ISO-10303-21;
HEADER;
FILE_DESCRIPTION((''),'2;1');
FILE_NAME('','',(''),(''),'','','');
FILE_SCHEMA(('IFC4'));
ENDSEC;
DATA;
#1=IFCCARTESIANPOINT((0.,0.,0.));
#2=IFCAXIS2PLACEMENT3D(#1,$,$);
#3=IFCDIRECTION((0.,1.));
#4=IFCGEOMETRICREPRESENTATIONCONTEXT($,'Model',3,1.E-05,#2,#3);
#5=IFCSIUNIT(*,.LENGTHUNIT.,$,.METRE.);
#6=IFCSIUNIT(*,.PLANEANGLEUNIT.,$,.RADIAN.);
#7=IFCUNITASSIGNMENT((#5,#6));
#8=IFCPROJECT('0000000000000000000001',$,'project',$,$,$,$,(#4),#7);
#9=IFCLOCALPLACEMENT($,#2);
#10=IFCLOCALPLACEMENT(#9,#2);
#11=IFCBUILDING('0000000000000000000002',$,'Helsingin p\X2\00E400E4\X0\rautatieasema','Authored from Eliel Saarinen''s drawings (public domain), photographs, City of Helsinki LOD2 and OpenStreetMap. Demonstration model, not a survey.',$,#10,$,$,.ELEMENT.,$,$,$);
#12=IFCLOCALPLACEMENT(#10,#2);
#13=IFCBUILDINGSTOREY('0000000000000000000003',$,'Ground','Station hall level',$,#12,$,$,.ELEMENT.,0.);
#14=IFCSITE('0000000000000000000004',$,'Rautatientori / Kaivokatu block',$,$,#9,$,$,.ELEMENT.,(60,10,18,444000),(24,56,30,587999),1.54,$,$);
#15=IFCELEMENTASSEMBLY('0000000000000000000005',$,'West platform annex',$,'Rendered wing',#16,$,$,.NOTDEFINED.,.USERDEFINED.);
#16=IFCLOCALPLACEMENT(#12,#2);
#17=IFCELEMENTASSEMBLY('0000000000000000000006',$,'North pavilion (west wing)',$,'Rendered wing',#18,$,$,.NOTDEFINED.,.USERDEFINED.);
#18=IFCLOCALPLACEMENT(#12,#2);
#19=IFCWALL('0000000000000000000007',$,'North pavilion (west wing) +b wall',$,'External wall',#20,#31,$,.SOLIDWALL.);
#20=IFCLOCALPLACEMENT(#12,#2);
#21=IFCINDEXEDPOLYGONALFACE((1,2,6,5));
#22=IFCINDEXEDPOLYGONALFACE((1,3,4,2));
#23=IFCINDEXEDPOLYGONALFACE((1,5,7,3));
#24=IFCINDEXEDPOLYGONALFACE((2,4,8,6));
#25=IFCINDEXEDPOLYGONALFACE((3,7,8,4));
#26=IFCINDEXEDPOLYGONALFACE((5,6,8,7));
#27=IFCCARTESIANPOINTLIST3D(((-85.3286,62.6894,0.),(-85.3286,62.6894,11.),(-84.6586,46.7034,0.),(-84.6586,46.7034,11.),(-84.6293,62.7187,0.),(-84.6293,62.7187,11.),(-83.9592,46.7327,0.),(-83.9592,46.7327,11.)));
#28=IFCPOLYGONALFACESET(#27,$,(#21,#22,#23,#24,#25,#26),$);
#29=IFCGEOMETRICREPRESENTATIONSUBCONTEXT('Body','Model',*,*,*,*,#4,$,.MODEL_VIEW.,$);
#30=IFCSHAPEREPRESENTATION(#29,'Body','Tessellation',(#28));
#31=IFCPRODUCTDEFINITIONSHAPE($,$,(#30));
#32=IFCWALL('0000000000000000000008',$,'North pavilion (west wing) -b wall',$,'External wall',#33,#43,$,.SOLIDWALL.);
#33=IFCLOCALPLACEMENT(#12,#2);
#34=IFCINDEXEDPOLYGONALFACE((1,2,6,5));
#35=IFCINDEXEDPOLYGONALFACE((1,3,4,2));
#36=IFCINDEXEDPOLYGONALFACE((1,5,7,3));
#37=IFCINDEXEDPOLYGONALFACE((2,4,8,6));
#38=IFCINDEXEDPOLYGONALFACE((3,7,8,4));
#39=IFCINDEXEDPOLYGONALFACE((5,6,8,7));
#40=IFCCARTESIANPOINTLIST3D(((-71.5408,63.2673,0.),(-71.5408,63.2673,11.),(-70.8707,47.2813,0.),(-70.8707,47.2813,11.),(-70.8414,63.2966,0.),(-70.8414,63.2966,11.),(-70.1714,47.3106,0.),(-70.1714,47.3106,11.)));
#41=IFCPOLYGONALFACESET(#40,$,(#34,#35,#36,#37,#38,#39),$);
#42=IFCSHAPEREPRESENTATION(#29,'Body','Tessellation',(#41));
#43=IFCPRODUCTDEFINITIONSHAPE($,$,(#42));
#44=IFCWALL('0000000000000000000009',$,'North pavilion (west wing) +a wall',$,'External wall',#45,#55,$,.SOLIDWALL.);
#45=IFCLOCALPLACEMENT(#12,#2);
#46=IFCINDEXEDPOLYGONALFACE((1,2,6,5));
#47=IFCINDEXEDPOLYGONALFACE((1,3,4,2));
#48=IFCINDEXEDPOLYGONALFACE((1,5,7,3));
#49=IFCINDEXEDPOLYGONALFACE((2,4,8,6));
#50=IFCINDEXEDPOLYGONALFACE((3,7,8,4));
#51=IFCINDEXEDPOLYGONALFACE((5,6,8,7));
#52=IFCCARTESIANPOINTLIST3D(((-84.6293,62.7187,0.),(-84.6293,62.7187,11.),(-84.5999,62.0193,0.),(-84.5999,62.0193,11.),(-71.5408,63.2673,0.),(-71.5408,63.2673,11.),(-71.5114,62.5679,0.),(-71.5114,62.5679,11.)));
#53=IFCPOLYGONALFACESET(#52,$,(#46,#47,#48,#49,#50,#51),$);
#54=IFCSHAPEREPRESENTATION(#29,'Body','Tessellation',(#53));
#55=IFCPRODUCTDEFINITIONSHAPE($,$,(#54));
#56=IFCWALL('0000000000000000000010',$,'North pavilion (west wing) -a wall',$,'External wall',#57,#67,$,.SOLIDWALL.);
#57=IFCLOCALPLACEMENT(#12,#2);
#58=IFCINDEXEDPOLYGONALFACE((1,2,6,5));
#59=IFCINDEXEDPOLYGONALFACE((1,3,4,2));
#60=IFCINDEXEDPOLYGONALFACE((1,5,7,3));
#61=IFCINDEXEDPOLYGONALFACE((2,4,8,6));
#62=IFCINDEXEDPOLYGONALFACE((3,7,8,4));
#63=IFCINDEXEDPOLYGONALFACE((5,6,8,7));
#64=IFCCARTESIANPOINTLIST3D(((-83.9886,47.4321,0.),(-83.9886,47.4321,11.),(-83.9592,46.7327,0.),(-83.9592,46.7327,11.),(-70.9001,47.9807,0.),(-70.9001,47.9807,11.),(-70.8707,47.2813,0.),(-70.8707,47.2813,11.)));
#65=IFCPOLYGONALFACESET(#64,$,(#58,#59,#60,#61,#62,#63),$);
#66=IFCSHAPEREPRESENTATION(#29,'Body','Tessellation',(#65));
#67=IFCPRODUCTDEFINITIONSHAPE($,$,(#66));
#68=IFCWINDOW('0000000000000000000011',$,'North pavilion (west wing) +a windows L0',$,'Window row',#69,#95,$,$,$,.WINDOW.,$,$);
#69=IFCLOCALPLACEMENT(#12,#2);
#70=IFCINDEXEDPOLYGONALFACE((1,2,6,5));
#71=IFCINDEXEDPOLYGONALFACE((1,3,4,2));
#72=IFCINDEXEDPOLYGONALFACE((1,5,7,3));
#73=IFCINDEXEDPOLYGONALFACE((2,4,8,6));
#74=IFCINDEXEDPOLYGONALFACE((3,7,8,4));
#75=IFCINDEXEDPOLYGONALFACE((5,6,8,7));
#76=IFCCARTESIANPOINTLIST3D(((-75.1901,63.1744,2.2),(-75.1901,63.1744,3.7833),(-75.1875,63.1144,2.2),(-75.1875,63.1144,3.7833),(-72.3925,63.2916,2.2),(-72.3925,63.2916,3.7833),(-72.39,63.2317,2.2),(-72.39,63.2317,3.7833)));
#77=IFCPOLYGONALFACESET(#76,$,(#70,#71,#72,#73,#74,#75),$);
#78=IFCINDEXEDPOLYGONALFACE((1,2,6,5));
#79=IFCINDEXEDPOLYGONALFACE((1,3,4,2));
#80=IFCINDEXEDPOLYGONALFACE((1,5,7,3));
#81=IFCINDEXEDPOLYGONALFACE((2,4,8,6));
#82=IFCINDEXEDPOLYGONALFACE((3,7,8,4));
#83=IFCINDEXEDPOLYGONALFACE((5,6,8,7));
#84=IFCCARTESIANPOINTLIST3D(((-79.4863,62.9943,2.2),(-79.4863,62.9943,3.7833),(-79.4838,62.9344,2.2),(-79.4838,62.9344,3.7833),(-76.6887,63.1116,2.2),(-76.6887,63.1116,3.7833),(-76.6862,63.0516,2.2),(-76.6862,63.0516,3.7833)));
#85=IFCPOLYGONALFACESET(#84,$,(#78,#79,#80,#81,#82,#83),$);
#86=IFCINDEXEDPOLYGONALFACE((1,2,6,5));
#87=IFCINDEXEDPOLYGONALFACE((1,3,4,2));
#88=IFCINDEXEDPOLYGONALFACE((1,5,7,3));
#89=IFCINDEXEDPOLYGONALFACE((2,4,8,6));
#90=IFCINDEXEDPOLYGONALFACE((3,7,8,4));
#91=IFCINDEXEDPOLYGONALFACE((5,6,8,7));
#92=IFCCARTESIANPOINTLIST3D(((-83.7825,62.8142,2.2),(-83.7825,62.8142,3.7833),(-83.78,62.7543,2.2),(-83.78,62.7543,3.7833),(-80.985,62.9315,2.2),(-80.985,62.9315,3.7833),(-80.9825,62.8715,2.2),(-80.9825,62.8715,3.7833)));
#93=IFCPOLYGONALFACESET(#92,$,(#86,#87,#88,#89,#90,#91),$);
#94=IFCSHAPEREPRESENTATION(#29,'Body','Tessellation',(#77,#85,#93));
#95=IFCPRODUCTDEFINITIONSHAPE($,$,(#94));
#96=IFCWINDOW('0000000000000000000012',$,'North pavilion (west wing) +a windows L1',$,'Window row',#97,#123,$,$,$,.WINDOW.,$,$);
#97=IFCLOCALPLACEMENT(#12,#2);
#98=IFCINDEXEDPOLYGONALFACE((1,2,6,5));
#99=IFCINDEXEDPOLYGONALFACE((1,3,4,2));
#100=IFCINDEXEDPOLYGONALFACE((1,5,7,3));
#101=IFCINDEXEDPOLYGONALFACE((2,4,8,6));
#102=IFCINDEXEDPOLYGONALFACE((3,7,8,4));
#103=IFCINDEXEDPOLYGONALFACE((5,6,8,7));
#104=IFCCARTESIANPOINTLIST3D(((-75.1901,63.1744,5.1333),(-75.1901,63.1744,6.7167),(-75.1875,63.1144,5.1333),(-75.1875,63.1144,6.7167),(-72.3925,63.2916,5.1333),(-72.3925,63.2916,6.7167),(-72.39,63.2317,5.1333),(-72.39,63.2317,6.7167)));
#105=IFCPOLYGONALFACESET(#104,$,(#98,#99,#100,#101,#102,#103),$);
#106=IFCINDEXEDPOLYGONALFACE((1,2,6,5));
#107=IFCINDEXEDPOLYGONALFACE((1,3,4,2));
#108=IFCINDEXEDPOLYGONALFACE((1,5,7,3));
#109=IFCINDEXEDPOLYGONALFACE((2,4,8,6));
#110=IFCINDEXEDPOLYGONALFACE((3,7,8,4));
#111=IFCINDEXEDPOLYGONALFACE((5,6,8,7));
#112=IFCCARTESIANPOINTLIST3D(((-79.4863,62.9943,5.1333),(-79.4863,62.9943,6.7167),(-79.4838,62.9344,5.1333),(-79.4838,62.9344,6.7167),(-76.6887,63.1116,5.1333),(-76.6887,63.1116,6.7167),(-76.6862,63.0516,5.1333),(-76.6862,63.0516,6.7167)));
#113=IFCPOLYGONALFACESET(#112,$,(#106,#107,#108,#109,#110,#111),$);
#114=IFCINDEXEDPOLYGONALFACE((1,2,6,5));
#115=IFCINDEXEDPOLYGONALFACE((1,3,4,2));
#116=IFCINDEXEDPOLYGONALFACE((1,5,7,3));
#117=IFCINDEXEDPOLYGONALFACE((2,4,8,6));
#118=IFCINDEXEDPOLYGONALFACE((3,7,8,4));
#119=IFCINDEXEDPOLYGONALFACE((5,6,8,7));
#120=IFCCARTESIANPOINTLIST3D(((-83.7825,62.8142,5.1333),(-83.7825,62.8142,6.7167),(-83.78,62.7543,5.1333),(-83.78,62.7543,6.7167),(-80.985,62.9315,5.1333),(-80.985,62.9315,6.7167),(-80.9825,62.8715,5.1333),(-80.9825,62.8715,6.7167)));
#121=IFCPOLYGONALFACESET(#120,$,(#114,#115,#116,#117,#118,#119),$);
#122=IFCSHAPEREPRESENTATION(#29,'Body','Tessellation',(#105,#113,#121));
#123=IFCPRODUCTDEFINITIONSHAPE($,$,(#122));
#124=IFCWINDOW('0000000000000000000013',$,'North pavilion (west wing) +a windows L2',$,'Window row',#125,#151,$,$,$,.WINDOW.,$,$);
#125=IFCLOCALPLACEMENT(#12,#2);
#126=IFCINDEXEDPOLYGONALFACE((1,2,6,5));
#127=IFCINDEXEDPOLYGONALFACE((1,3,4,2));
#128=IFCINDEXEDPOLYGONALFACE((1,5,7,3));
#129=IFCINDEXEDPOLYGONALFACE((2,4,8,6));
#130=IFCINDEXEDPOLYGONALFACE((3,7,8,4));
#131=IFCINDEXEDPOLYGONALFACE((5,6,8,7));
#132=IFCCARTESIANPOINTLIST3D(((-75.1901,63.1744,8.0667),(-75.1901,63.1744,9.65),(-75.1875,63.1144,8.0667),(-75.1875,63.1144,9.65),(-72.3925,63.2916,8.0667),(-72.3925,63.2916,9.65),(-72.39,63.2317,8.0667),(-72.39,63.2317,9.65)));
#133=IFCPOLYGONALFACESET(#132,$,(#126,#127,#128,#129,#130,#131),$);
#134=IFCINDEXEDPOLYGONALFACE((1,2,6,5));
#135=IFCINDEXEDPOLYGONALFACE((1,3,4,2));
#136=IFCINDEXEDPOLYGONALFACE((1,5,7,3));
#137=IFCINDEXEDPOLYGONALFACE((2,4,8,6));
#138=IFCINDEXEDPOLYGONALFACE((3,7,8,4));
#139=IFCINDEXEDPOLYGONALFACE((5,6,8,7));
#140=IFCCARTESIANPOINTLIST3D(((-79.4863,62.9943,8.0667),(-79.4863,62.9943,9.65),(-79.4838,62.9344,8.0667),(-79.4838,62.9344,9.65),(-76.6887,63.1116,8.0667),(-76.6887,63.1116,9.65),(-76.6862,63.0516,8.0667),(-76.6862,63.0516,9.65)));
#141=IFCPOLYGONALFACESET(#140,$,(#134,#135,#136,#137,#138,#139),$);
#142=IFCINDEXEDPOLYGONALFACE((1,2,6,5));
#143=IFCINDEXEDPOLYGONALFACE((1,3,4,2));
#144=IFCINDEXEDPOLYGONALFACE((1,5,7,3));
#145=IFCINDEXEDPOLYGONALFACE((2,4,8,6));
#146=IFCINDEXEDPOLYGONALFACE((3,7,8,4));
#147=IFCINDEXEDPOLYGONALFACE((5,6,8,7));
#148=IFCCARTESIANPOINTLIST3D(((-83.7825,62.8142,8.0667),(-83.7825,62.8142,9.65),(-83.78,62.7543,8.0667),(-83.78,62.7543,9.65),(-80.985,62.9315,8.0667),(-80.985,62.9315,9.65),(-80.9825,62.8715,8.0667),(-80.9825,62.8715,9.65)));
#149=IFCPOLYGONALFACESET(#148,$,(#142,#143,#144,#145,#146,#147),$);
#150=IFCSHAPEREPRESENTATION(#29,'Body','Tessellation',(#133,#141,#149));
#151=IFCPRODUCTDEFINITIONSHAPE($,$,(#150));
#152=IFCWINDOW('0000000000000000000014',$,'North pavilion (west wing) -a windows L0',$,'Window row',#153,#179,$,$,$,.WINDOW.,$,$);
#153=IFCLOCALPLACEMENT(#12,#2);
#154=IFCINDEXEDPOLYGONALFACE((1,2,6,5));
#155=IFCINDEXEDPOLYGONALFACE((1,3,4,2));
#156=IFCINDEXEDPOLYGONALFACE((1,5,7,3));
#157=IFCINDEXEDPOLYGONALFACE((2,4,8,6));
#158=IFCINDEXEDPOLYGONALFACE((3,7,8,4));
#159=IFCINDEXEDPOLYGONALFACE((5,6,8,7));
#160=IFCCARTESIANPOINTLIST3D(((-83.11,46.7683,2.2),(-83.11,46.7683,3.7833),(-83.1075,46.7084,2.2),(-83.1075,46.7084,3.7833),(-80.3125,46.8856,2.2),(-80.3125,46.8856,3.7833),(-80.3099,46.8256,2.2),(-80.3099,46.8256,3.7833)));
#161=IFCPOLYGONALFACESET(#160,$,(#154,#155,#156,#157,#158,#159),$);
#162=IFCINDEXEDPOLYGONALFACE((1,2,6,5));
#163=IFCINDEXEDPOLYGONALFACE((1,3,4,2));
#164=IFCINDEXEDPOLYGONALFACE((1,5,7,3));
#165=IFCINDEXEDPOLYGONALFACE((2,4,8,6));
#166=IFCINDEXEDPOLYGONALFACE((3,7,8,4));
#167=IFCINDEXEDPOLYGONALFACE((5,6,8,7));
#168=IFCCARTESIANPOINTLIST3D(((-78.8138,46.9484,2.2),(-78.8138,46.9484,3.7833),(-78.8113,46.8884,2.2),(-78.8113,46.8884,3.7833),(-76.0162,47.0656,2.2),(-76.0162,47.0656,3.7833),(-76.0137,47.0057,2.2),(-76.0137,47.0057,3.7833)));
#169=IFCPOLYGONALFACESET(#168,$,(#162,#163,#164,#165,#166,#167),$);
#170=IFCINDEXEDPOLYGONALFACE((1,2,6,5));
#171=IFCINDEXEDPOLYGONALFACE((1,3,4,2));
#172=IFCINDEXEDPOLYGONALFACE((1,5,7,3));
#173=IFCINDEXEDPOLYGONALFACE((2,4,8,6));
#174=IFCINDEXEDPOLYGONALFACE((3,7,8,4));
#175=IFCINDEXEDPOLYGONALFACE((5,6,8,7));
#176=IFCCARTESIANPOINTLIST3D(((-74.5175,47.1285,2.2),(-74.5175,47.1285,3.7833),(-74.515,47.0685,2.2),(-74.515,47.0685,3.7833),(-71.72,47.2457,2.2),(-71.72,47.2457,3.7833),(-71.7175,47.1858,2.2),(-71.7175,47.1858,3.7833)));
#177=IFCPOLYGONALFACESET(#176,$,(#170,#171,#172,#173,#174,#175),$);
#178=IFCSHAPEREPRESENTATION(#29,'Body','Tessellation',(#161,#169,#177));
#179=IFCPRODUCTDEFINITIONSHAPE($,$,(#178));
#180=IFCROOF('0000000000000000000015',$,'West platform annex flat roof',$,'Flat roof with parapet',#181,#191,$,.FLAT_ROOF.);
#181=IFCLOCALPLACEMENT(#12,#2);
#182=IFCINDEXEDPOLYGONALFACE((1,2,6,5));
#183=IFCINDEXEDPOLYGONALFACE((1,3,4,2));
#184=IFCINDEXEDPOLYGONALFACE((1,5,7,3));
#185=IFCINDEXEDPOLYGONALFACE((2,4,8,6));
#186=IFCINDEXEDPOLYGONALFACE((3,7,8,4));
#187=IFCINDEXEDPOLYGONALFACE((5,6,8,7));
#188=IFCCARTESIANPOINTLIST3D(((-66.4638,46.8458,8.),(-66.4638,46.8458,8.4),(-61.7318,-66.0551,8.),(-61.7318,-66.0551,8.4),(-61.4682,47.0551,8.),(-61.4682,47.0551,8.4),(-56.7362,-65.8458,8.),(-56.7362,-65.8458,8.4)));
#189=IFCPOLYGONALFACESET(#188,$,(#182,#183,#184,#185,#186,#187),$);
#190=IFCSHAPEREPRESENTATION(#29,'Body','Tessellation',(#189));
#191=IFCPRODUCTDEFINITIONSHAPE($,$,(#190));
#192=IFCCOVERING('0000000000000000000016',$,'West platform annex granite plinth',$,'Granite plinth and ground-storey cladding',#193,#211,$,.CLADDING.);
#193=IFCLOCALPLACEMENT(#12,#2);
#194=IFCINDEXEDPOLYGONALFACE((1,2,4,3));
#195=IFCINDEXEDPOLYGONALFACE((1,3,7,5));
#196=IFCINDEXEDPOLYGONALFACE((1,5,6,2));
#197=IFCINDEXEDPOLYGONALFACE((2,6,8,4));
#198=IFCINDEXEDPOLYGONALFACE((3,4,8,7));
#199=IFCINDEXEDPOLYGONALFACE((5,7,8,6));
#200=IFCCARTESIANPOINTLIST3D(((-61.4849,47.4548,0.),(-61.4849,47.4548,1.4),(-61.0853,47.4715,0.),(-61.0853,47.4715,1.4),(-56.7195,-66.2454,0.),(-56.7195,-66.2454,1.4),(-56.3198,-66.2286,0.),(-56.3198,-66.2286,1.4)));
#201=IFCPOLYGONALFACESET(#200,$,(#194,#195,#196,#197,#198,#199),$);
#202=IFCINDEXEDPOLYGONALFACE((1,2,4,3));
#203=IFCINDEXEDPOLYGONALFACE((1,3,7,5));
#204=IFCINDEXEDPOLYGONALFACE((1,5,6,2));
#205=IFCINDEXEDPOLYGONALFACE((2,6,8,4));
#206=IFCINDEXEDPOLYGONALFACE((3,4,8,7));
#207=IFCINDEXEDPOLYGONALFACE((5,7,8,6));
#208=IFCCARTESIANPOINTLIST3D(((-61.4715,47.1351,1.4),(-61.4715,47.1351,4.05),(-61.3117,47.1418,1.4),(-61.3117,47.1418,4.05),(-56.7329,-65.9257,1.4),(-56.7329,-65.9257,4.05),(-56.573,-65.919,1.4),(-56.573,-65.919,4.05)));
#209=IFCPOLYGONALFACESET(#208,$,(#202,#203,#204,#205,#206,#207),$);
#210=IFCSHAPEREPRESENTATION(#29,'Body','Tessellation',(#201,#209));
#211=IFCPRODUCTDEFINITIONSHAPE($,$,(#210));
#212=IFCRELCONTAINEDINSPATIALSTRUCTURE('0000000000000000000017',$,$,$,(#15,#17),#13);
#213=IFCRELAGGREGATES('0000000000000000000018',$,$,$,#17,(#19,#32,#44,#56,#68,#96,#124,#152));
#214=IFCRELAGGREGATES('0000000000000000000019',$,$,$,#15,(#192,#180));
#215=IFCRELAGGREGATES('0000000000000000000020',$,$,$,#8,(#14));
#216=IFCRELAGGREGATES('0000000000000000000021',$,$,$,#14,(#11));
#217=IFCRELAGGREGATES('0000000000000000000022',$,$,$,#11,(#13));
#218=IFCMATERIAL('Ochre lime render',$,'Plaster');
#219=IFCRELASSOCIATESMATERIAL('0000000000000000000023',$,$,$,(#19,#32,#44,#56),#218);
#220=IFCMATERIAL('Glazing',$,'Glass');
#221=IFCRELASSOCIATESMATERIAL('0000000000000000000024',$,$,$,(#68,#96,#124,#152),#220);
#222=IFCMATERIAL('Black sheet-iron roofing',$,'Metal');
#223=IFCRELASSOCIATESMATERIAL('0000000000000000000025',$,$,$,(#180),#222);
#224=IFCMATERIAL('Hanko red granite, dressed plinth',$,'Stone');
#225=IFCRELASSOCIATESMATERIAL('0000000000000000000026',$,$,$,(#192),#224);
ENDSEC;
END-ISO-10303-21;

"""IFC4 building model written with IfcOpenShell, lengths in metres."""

from ifc_helpers import new_model, si_unit, direction, frame, frame_2d, origin, place, context, subcontext, project, spatial, rectangle, extrude, material, element, aggregate, save


model = new_model("IFC4")

# Units and contexts
model_context = context("Model", 3, precision=1e-05, world=origin(), true_north=direction((0.0, 1.0)))
body_context = subcontext(model_context, "Body", "Model", "MODEL_VIEW")
ifc_project = project(units=[si_unit("LENGTHUNIT", "METRE"), si_unit("PLANEANGLEUNIT", "RADIAN")], contexts=[model_context])

# Site, building, storey
site_placement = place(None, origin())
site = spatial("IfcSite", under=ifc_project, at=site_placement, Name="Rautatientori / Kaivokatu block", CompositionType="ELEMENT", RefLatitude=(60, 10, 18, 444000), RefLongitude=(24, 56, 30, 587999), RefElevation=1.54)
building_placement = place(site_placement, origin())
building = spatial("IfcBuilding", under=site, at=building_placement, Name="Helsingin päärautatieasema", Description="Authored from Eliel Saarinen's drawings (public domain), photographs, City of Helsinki LOD2 and OpenStreetMap. Demonstration model, not a survey.", CompositionType="ELEMENT")
storey_placement = place(building_placement, origin())
storey = spatial("IfcBuildingStorey", under=building, at=storey_placement, Name="Ground", Description="Station hall level", CompositionType="ELEMENT", Elevation=0.0)

# Element assembly
assembly_1_placement = place(building_placement, origin())
assembly_1 = element("IfcElementAssembly", 1, at=assembly_1_placement, inside=storey, Name="West platform annex", ObjectType="Rendered wing", AssemblyPlace="NOTDEFINED", PredefinedType="USERDEFINED")
ifc_material_1 = material(Name="Hanko red granite, dressed plinth", Category="Stone")
ifc_material_2 = material(Name="Ochre lime render", Category="Plaster")

# Element assembly
assembly_2_placement = place(building_placement, origin())
assembly_2 = element("IfcElementAssembly", 2, at=assembly_2_placement, inside=storey, Name="North pavilion (west wing)", ObjectType="Rendered wing", AssemblyPlace="NOTDEFINED", PredefinedType="USERDEFINED")

# Shared definitions
ifc_material_3 = material(Name="Glazing", Category="Glass")

# Walls
wall_1_placement = place(building_placement, origin())
wall_1 = element("IfcWall", 3, at=wall_1_placement, material=ifc_material_2, Name="North pavilion (west wing) +b wall", ObjectType="External wall", PredefinedType="SOLIDWALL", context=body_context, shape_type="SweptSolid", body=[
    extrude(rectangle(XDim=16.0, YDim=0.7, at=frame_2d((0.0, 0.0), x_axis=(0.041876, -0.999123))), frame((-84.6439, 54.7111, 0.0)), (0.0, 0.0, 1.0), 11.0),
])
wall_2_placement = place(building_placement, origin())
wall_2 = element("IfcWall", 4, at=wall_2_placement, material=ifc_material_2, Name="North pavilion (west wing) -b wall", ObjectType="External wall", PredefinedType="SOLIDWALL", context=body_context, shape_type="SweptSolid", body=[
    extrude(rectangle(XDim=16.0, YDim=0.7, at=frame_2d((0.0, 0.0), x_axis=(-0.041876, 0.999123))), frame((-70.8561, 55.2889, 0.0)), (0.0, 0.0, 1.0), 11.0),
])
wall_3_placement = place(building_placement, origin())
wall_3 = element("IfcWall", 5, at=wall_3_placement, material=ifc_material_2, Name="North pavilion (west wing) +a wall", ObjectType="External wall", PredefinedType="SOLIDWALL", context=body_context, shape_type="SweptSolid", body=[
    extrude(rectangle(XDim=13.1, YDim=0.7, at=frame_2d((0.0, 0.0), x_axis=(-0.999123, -0.041876))), frame((-78.0703, 62.6433, 0.0)), (0.0, 0.0, 1.0), 11.0),
])
wall_4_placement = place(building_placement, origin())
wall_4 = element("IfcWall", 6, at=wall_4_placement, material=ifc_material_2, Name="North pavilion (west wing) -a wall", ObjectType="External wall", PredefinedType="SOLIDWALL", context=body_context, shape_type="SweptSolid", body=[
    extrude(rectangle(XDim=13.1, YDim=0.7, at=frame_2d((0.0, 0.0), x_axis=(0.999123, 0.041876))), frame((-77.4297, 47.3567, 0.0)), (0.0, 0.0, 1.0), 11.0),
])

# Windows
window_1_placement = place(building_placement, origin())
window_1 = element("IfcWindow", 7, at=window_1_placement, material=ifc_material_3, Name="North pavilion (west wing) +a windows L0", ObjectType="Window row", PredefinedType="WINDOW", context=body_context, shape_type="SweptSolid", body=[
    extrude(rectangle(XDim=2.8, YDim=0.06, at=frame_2d((0.0, 0.0), x_axis=(-0.999123, -0.041876))), frame((-73.79, 63.203, 2.2)), (0.0, 0.0, 1.0), 1.5833),
    extrude(rectangle(XDim=2.8, YDim=0.06, at=frame_2d((0.0, 0.0), x_axis=(-0.999123, -0.041876))), frame((-78.0863, 63.023, 2.2)), (0.0, 0.0, 1.0), 1.5833),
    extrude(rectangle(XDim=2.8, YDim=0.06, at=frame_2d((0.0, 0.0), x_axis=(-0.999123, -0.041876))), frame((-82.3825, 62.8429, 2.2)), (0.0, 0.0, 1.0), 1.5833),
])
window_2_placement = place(building_placement, origin())
window_2 = element("IfcWindow", 8, at=window_2_placement, material=ifc_material_3, Name="North pavilion (west wing) +a windows L1", ObjectType="Window row", PredefinedType="WINDOW", context=body_context, shape_type="SweptSolid", body=[
    extrude(rectangle(XDim=2.8, YDim=0.06, at=frame_2d((0.0, 0.0), x_axis=(-0.999123, -0.041876))), frame((-73.79, 63.203, 5.1333)), (0.0, 0.0, 1.0), 1.5833),
    extrude(rectangle(XDim=2.8, YDim=0.06, at=frame_2d((0.0, 0.0), x_axis=(-0.999123, -0.041876))), frame((-78.0863, 63.023, 5.1333)), (0.0, 0.0, 1.0), 1.5833),
    extrude(rectangle(XDim=2.8, YDim=0.06, at=frame_2d((0.0, 0.0), x_axis=(-0.999123, -0.041876))), frame((-82.3825, 62.8429, 5.1333)), (0.0, 0.0, 1.0), 1.5833),
])
window_3_placement = place(building_placement, origin())
window_3 = element("IfcWindow", 9, at=window_3_placement, material=ifc_material_3, Name="North pavilion (west wing) +a windows L2", ObjectType="Window row", PredefinedType="WINDOW", context=body_context, shape_type="SweptSolid", body=[
    extrude(rectangle(XDim=2.8, YDim=0.06, at=frame_2d((0.0, 0.0), x_axis=(-0.999123, -0.041876))), frame((-73.79, 63.203, 8.0667)), (0.0, 0.0, 1.0), 1.5833),
    extrude(rectangle(XDim=2.8, YDim=0.06, at=frame_2d((0.0, 0.0), x_axis=(-0.999123, -0.041876))), frame((-78.0863, 63.023, 8.0667)), (0.0, 0.0, 1.0), 1.5833),
    extrude(rectangle(XDim=2.8, YDim=0.06, at=frame_2d((0.0, 0.0), x_axis=(-0.999123, -0.041876))), frame((-82.3825, 62.8429, 8.0667)), (0.0, 0.0, 1.0), 1.5833),
])
window_4_placement = place(building_placement, origin())
window_4 = element("IfcWindow", 10, at=window_4_placement, material=ifc_material_3, Name="North pavilion (west wing) -a windows L0", ObjectType="Window row", PredefinedType="WINDOW", context=body_context, shape_type="SweptSolid", body=[
    extrude(rectangle(XDim=2.8, YDim=0.06, at=frame_2d((0.0, 0.0), x_axis=(0.999123, 0.041876))), frame((-81.71, 46.797, 2.2)), (0.0, 0.0, 1.0), 1.5833),
    extrude(rectangle(XDim=2.8, YDim=0.06, at=frame_2d((0.0, 0.0), x_axis=(0.999123, 0.041876))), frame((-77.4137, 46.977, 2.2)), (0.0, 0.0, 1.0), 1.5833),
    extrude(rectangle(XDim=2.8, YDim=0.06, at=frame_2d((0.0, 0.0), x_axis=(0.999123, 0.041876))), frame((-73.1175, 47.1571, 2.2)), (0.0, 0.0, 1.0), 1.5833),
])
aggregate(assembly_2, [wall_1, wall_2, wall_3, wall_4, window_1, window_2, window_3, window_4])

# Roof
ifc_material_4 = material(Name="Black sheet-iron roofing", Category="Metal")
roof_placement = place(building_placement, origin())
roof = element("IfcRoof", 11, at=roof_placement, material=ifc_material_4, Name="West platform annex flat roof", ObjectType="Flat roof with parapet", PredefinedType="FLAT_ROOF", context=body_context, shape_type="SweptSolid", body=[
    extrude(rectangle(XDim=113.0, YDim=5.0, at=frame_2d((0.0, 0.0), x_axis=(-0.041876, 0.999123))), frame((-61.6, -9.5, 8.0)), (0.0, 0.0, 1.0), 0.4),
])

# Covering
covering_placement = place(building_placement, origin())
covering = element("IfcCovering", 12, at=covering_placement, material=ifc_material_1, Name="West platform annex granite plinth", ObjectType="Granite plinth and ground-storey cladding", PredefinedType="CLADDING", context=body_context, shape_type="SweptSolid", body=[
    extrude(rectangle(XDim=113.8, YDim=0.4, at=frame_2d((0.0, 0.0), x_axis=(-0.041876, 0.999123))), frame((-58.9024, -9.3869, 0.0)), (0.0, 0.0, 1.0), 1.4),
    extrude(rectangle(XDim=113.16, YDim=0.16, at=frame_2d((0.0, 0.0), x_axis=(-0.041876, 0.999123))), frame((-59.0223, -9.392, 1.4)), (0.0, 0.0, 1.0), 2.65),
])
aggregate(assembly_1, [covering, roof])

save(model, "model.ifc")
